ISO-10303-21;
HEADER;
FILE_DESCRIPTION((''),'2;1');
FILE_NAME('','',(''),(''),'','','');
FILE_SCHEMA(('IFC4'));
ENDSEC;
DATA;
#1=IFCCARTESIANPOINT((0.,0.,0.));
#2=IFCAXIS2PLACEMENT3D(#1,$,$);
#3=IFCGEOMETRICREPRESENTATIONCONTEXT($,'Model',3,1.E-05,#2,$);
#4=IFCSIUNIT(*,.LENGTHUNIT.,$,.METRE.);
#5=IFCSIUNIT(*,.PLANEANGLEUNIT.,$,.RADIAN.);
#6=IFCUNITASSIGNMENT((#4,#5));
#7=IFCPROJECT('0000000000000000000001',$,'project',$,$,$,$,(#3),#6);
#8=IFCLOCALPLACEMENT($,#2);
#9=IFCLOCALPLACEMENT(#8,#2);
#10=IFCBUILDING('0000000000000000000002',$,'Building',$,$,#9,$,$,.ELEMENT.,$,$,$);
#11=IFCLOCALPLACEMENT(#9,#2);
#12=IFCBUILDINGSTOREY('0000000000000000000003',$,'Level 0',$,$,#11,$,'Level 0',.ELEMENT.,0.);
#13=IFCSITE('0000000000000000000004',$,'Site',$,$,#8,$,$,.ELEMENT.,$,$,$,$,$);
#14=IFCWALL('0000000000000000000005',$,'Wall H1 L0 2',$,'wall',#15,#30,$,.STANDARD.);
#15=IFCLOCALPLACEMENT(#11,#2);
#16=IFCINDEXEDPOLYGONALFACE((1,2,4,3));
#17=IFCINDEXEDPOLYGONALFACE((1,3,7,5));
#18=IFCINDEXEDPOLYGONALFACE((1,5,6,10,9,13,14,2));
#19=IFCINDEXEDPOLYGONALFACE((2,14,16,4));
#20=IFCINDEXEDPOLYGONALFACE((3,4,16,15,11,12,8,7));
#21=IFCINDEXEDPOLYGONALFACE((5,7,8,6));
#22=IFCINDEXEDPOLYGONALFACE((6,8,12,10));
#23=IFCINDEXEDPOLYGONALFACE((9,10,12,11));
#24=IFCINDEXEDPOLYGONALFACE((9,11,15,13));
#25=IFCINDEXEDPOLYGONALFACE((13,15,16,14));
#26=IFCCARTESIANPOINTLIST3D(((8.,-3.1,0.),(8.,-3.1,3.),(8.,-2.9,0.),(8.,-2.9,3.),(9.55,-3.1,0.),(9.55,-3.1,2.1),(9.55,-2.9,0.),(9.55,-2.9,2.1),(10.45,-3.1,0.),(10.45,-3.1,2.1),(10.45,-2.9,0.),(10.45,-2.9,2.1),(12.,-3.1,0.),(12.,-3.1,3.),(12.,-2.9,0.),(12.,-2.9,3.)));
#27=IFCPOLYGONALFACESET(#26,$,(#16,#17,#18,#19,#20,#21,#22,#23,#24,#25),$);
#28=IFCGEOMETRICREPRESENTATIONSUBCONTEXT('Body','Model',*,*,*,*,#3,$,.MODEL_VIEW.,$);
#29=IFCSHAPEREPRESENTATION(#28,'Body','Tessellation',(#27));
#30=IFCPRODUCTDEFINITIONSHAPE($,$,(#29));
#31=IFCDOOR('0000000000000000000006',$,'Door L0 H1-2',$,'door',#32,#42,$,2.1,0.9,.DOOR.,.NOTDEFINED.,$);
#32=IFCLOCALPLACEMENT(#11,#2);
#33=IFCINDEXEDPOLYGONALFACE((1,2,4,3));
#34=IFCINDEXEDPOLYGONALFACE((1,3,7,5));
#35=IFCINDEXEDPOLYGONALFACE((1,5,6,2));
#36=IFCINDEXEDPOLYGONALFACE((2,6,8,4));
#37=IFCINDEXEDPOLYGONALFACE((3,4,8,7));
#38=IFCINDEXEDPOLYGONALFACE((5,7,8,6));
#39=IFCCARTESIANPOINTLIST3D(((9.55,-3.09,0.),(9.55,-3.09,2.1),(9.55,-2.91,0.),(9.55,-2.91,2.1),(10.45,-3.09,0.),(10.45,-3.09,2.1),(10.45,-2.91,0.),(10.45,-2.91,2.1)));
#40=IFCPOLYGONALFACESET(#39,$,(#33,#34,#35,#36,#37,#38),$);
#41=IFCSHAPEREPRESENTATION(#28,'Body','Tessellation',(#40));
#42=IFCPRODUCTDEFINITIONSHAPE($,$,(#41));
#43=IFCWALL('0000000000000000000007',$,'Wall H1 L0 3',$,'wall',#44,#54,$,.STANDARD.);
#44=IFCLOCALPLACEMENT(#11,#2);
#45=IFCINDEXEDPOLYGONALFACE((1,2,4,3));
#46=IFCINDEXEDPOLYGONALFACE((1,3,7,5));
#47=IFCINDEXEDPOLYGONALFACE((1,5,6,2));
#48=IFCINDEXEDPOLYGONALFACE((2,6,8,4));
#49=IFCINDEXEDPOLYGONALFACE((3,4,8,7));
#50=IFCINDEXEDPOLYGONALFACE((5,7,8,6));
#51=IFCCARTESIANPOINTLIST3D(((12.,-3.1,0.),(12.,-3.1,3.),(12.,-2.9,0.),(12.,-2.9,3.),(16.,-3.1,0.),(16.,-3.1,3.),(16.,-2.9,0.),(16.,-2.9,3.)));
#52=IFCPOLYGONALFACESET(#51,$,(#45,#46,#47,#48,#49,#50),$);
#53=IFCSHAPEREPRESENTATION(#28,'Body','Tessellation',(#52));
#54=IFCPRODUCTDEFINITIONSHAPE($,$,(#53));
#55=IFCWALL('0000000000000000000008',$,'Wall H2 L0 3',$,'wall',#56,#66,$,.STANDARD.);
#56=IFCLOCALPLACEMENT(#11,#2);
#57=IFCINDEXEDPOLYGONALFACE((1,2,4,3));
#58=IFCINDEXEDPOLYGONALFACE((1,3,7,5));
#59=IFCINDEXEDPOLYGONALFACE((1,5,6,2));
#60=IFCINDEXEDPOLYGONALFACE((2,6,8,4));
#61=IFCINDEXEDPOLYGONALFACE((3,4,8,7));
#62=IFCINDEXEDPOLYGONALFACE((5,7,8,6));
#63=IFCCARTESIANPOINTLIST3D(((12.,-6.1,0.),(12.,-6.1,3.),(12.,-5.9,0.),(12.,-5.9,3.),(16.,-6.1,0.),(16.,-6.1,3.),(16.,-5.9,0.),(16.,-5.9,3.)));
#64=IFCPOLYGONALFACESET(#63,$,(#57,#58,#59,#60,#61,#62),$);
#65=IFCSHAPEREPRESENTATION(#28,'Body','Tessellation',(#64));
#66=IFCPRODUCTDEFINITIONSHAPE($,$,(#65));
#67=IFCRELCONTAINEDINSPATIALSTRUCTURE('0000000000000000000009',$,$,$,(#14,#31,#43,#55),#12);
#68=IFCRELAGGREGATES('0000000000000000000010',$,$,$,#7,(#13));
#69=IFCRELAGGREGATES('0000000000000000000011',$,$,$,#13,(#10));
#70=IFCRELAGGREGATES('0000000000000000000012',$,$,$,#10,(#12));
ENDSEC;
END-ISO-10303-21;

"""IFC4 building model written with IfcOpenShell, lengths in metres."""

from ifc_helpers import new_model, si_unit, frame, frame_2d, origin, origin_2d, place, context, subcontext, project, spatial, rectangle, extrude, element, fill, save


model = new_model("IFC4")

# Units and contexts
model_context = context("Model", 3, precision=1e-05, world=origin())
body_context = subcontext(model_context, "Body", "Model", "MODEL_VIEW")
ifc_project = project(units=[si_unit("LENGTHUNIT", "METRE"), si_unit("PLANEANGLEUNIT", "RADIAN")], contexts=[model_context])

# Site, building, storey
site_placement = place(None, origin())
site = spatial("IfcSite", under=ifc_project, at=site_placement, Name="Site", CompositionType="ELEMENT")
building_placement = place(site_placement, origin())
building = spatial("IfcBuilding", under=site, at=building_placement, Name="Building", CompositionType="ELEMENT")
storey_placement = place(building_placement, origin())
storey = spatial("IfcBuildingStorey", under=building, at=storey_placement, Name="Level 0", LongName="Level 0", CompositionType="ELEMENT", Elevation=0.0)

# Wall, opening, door
wall_1_placement = place(storey_placement, frame((8.0, -3.0, 0.0), z_axis=(0.0, 0.0, 1.0), x_axis=(1.0, 0.0, 0.0)))
wall_1 = element("IfcWall", 1, at=wall_1_placement, inside=storey, Name="Wall H1 L0 2", ObjectType="wall", PredefinedType="STANDARD", context=body_context, shape_type="SweptSolid", body=[
    extrude(rectangle(XDim=4.0, YDim=0.2, at=frame_2d((2.0, 0.0))), origin(), (0.0, 0.0, 1.0), 3.0),
])
opening_1_placement = place(storey_placement, frame((10.0, -3.0, 0.0), z_axis=(0.0, 0.0, 1.0), x_axis=(1.0, 0.0, 0.0)))
opening_1 = element("IfcOpeningElement", 2, at=opening_1_placement, cuts=wall_1, ObjectType="Opening", PredefinedType="OPENING", context=body_context, shape_type="SweptSolid", body=[
    extrude(rectangle(XDim=0.9, YDim=0.22, at=origin_2d()), origin(), (0.0, 0.0, 1.0), 2.1),
])
door_1_placement = place(storey_placement, frame((10.0, -3.0, 0.0), z_axis=(0.0, 0.0, 1.0), x_axis=(1.0, 0.0, 0.0)))
door_1 = element("IfcDoor", 3, at=door_1_placement, inside=storey, Name="Door L0 H1-2", ObjectType="door", OperationType="NOTDEFINED", OverallHeight=2.1, OverallWidth=0.9, PredefinedType="DOOR", context=body_context, shape_type="SweptSolid", body=[
    extrude(rectangle(XDim=0.9, YDim=0.18, at=origin_2d()), origin(), (0.0, 0.0, 1.0), 2.1),
])
fill(opening_1, door_1)

# Walls
for number, where, z_axis, x_axis, name in (
    (4, (12.0, -3.0, 0.0), (0.0, 0.0, 1.0), (1.0, 0.0, 0.0), "Wall H1 L0 3"),
    (5, (12.0, -6.0, 0.0), (0.0, 0.0, 1.0), (1.0, 0.0, 0.0), "Wall H2 L0 3"),
):
    element("IfcWall", number, at=place(storey_placement, frame(where, z_axis=z_axis, x_axis=x_axis)), inside=storey, Name=name, ObjectType="wall", PredefinedType="STANDARD", context=body_context, shape_type="SweptSolid", body=[
        extrude(rectangle(XDim=4.0, YDim=0.2, at=frame_2d((2.0, 0.0))), origin(), (0.0, 0.0, 1.0), 3.0),
    ])

save(model, "model.ifc")
